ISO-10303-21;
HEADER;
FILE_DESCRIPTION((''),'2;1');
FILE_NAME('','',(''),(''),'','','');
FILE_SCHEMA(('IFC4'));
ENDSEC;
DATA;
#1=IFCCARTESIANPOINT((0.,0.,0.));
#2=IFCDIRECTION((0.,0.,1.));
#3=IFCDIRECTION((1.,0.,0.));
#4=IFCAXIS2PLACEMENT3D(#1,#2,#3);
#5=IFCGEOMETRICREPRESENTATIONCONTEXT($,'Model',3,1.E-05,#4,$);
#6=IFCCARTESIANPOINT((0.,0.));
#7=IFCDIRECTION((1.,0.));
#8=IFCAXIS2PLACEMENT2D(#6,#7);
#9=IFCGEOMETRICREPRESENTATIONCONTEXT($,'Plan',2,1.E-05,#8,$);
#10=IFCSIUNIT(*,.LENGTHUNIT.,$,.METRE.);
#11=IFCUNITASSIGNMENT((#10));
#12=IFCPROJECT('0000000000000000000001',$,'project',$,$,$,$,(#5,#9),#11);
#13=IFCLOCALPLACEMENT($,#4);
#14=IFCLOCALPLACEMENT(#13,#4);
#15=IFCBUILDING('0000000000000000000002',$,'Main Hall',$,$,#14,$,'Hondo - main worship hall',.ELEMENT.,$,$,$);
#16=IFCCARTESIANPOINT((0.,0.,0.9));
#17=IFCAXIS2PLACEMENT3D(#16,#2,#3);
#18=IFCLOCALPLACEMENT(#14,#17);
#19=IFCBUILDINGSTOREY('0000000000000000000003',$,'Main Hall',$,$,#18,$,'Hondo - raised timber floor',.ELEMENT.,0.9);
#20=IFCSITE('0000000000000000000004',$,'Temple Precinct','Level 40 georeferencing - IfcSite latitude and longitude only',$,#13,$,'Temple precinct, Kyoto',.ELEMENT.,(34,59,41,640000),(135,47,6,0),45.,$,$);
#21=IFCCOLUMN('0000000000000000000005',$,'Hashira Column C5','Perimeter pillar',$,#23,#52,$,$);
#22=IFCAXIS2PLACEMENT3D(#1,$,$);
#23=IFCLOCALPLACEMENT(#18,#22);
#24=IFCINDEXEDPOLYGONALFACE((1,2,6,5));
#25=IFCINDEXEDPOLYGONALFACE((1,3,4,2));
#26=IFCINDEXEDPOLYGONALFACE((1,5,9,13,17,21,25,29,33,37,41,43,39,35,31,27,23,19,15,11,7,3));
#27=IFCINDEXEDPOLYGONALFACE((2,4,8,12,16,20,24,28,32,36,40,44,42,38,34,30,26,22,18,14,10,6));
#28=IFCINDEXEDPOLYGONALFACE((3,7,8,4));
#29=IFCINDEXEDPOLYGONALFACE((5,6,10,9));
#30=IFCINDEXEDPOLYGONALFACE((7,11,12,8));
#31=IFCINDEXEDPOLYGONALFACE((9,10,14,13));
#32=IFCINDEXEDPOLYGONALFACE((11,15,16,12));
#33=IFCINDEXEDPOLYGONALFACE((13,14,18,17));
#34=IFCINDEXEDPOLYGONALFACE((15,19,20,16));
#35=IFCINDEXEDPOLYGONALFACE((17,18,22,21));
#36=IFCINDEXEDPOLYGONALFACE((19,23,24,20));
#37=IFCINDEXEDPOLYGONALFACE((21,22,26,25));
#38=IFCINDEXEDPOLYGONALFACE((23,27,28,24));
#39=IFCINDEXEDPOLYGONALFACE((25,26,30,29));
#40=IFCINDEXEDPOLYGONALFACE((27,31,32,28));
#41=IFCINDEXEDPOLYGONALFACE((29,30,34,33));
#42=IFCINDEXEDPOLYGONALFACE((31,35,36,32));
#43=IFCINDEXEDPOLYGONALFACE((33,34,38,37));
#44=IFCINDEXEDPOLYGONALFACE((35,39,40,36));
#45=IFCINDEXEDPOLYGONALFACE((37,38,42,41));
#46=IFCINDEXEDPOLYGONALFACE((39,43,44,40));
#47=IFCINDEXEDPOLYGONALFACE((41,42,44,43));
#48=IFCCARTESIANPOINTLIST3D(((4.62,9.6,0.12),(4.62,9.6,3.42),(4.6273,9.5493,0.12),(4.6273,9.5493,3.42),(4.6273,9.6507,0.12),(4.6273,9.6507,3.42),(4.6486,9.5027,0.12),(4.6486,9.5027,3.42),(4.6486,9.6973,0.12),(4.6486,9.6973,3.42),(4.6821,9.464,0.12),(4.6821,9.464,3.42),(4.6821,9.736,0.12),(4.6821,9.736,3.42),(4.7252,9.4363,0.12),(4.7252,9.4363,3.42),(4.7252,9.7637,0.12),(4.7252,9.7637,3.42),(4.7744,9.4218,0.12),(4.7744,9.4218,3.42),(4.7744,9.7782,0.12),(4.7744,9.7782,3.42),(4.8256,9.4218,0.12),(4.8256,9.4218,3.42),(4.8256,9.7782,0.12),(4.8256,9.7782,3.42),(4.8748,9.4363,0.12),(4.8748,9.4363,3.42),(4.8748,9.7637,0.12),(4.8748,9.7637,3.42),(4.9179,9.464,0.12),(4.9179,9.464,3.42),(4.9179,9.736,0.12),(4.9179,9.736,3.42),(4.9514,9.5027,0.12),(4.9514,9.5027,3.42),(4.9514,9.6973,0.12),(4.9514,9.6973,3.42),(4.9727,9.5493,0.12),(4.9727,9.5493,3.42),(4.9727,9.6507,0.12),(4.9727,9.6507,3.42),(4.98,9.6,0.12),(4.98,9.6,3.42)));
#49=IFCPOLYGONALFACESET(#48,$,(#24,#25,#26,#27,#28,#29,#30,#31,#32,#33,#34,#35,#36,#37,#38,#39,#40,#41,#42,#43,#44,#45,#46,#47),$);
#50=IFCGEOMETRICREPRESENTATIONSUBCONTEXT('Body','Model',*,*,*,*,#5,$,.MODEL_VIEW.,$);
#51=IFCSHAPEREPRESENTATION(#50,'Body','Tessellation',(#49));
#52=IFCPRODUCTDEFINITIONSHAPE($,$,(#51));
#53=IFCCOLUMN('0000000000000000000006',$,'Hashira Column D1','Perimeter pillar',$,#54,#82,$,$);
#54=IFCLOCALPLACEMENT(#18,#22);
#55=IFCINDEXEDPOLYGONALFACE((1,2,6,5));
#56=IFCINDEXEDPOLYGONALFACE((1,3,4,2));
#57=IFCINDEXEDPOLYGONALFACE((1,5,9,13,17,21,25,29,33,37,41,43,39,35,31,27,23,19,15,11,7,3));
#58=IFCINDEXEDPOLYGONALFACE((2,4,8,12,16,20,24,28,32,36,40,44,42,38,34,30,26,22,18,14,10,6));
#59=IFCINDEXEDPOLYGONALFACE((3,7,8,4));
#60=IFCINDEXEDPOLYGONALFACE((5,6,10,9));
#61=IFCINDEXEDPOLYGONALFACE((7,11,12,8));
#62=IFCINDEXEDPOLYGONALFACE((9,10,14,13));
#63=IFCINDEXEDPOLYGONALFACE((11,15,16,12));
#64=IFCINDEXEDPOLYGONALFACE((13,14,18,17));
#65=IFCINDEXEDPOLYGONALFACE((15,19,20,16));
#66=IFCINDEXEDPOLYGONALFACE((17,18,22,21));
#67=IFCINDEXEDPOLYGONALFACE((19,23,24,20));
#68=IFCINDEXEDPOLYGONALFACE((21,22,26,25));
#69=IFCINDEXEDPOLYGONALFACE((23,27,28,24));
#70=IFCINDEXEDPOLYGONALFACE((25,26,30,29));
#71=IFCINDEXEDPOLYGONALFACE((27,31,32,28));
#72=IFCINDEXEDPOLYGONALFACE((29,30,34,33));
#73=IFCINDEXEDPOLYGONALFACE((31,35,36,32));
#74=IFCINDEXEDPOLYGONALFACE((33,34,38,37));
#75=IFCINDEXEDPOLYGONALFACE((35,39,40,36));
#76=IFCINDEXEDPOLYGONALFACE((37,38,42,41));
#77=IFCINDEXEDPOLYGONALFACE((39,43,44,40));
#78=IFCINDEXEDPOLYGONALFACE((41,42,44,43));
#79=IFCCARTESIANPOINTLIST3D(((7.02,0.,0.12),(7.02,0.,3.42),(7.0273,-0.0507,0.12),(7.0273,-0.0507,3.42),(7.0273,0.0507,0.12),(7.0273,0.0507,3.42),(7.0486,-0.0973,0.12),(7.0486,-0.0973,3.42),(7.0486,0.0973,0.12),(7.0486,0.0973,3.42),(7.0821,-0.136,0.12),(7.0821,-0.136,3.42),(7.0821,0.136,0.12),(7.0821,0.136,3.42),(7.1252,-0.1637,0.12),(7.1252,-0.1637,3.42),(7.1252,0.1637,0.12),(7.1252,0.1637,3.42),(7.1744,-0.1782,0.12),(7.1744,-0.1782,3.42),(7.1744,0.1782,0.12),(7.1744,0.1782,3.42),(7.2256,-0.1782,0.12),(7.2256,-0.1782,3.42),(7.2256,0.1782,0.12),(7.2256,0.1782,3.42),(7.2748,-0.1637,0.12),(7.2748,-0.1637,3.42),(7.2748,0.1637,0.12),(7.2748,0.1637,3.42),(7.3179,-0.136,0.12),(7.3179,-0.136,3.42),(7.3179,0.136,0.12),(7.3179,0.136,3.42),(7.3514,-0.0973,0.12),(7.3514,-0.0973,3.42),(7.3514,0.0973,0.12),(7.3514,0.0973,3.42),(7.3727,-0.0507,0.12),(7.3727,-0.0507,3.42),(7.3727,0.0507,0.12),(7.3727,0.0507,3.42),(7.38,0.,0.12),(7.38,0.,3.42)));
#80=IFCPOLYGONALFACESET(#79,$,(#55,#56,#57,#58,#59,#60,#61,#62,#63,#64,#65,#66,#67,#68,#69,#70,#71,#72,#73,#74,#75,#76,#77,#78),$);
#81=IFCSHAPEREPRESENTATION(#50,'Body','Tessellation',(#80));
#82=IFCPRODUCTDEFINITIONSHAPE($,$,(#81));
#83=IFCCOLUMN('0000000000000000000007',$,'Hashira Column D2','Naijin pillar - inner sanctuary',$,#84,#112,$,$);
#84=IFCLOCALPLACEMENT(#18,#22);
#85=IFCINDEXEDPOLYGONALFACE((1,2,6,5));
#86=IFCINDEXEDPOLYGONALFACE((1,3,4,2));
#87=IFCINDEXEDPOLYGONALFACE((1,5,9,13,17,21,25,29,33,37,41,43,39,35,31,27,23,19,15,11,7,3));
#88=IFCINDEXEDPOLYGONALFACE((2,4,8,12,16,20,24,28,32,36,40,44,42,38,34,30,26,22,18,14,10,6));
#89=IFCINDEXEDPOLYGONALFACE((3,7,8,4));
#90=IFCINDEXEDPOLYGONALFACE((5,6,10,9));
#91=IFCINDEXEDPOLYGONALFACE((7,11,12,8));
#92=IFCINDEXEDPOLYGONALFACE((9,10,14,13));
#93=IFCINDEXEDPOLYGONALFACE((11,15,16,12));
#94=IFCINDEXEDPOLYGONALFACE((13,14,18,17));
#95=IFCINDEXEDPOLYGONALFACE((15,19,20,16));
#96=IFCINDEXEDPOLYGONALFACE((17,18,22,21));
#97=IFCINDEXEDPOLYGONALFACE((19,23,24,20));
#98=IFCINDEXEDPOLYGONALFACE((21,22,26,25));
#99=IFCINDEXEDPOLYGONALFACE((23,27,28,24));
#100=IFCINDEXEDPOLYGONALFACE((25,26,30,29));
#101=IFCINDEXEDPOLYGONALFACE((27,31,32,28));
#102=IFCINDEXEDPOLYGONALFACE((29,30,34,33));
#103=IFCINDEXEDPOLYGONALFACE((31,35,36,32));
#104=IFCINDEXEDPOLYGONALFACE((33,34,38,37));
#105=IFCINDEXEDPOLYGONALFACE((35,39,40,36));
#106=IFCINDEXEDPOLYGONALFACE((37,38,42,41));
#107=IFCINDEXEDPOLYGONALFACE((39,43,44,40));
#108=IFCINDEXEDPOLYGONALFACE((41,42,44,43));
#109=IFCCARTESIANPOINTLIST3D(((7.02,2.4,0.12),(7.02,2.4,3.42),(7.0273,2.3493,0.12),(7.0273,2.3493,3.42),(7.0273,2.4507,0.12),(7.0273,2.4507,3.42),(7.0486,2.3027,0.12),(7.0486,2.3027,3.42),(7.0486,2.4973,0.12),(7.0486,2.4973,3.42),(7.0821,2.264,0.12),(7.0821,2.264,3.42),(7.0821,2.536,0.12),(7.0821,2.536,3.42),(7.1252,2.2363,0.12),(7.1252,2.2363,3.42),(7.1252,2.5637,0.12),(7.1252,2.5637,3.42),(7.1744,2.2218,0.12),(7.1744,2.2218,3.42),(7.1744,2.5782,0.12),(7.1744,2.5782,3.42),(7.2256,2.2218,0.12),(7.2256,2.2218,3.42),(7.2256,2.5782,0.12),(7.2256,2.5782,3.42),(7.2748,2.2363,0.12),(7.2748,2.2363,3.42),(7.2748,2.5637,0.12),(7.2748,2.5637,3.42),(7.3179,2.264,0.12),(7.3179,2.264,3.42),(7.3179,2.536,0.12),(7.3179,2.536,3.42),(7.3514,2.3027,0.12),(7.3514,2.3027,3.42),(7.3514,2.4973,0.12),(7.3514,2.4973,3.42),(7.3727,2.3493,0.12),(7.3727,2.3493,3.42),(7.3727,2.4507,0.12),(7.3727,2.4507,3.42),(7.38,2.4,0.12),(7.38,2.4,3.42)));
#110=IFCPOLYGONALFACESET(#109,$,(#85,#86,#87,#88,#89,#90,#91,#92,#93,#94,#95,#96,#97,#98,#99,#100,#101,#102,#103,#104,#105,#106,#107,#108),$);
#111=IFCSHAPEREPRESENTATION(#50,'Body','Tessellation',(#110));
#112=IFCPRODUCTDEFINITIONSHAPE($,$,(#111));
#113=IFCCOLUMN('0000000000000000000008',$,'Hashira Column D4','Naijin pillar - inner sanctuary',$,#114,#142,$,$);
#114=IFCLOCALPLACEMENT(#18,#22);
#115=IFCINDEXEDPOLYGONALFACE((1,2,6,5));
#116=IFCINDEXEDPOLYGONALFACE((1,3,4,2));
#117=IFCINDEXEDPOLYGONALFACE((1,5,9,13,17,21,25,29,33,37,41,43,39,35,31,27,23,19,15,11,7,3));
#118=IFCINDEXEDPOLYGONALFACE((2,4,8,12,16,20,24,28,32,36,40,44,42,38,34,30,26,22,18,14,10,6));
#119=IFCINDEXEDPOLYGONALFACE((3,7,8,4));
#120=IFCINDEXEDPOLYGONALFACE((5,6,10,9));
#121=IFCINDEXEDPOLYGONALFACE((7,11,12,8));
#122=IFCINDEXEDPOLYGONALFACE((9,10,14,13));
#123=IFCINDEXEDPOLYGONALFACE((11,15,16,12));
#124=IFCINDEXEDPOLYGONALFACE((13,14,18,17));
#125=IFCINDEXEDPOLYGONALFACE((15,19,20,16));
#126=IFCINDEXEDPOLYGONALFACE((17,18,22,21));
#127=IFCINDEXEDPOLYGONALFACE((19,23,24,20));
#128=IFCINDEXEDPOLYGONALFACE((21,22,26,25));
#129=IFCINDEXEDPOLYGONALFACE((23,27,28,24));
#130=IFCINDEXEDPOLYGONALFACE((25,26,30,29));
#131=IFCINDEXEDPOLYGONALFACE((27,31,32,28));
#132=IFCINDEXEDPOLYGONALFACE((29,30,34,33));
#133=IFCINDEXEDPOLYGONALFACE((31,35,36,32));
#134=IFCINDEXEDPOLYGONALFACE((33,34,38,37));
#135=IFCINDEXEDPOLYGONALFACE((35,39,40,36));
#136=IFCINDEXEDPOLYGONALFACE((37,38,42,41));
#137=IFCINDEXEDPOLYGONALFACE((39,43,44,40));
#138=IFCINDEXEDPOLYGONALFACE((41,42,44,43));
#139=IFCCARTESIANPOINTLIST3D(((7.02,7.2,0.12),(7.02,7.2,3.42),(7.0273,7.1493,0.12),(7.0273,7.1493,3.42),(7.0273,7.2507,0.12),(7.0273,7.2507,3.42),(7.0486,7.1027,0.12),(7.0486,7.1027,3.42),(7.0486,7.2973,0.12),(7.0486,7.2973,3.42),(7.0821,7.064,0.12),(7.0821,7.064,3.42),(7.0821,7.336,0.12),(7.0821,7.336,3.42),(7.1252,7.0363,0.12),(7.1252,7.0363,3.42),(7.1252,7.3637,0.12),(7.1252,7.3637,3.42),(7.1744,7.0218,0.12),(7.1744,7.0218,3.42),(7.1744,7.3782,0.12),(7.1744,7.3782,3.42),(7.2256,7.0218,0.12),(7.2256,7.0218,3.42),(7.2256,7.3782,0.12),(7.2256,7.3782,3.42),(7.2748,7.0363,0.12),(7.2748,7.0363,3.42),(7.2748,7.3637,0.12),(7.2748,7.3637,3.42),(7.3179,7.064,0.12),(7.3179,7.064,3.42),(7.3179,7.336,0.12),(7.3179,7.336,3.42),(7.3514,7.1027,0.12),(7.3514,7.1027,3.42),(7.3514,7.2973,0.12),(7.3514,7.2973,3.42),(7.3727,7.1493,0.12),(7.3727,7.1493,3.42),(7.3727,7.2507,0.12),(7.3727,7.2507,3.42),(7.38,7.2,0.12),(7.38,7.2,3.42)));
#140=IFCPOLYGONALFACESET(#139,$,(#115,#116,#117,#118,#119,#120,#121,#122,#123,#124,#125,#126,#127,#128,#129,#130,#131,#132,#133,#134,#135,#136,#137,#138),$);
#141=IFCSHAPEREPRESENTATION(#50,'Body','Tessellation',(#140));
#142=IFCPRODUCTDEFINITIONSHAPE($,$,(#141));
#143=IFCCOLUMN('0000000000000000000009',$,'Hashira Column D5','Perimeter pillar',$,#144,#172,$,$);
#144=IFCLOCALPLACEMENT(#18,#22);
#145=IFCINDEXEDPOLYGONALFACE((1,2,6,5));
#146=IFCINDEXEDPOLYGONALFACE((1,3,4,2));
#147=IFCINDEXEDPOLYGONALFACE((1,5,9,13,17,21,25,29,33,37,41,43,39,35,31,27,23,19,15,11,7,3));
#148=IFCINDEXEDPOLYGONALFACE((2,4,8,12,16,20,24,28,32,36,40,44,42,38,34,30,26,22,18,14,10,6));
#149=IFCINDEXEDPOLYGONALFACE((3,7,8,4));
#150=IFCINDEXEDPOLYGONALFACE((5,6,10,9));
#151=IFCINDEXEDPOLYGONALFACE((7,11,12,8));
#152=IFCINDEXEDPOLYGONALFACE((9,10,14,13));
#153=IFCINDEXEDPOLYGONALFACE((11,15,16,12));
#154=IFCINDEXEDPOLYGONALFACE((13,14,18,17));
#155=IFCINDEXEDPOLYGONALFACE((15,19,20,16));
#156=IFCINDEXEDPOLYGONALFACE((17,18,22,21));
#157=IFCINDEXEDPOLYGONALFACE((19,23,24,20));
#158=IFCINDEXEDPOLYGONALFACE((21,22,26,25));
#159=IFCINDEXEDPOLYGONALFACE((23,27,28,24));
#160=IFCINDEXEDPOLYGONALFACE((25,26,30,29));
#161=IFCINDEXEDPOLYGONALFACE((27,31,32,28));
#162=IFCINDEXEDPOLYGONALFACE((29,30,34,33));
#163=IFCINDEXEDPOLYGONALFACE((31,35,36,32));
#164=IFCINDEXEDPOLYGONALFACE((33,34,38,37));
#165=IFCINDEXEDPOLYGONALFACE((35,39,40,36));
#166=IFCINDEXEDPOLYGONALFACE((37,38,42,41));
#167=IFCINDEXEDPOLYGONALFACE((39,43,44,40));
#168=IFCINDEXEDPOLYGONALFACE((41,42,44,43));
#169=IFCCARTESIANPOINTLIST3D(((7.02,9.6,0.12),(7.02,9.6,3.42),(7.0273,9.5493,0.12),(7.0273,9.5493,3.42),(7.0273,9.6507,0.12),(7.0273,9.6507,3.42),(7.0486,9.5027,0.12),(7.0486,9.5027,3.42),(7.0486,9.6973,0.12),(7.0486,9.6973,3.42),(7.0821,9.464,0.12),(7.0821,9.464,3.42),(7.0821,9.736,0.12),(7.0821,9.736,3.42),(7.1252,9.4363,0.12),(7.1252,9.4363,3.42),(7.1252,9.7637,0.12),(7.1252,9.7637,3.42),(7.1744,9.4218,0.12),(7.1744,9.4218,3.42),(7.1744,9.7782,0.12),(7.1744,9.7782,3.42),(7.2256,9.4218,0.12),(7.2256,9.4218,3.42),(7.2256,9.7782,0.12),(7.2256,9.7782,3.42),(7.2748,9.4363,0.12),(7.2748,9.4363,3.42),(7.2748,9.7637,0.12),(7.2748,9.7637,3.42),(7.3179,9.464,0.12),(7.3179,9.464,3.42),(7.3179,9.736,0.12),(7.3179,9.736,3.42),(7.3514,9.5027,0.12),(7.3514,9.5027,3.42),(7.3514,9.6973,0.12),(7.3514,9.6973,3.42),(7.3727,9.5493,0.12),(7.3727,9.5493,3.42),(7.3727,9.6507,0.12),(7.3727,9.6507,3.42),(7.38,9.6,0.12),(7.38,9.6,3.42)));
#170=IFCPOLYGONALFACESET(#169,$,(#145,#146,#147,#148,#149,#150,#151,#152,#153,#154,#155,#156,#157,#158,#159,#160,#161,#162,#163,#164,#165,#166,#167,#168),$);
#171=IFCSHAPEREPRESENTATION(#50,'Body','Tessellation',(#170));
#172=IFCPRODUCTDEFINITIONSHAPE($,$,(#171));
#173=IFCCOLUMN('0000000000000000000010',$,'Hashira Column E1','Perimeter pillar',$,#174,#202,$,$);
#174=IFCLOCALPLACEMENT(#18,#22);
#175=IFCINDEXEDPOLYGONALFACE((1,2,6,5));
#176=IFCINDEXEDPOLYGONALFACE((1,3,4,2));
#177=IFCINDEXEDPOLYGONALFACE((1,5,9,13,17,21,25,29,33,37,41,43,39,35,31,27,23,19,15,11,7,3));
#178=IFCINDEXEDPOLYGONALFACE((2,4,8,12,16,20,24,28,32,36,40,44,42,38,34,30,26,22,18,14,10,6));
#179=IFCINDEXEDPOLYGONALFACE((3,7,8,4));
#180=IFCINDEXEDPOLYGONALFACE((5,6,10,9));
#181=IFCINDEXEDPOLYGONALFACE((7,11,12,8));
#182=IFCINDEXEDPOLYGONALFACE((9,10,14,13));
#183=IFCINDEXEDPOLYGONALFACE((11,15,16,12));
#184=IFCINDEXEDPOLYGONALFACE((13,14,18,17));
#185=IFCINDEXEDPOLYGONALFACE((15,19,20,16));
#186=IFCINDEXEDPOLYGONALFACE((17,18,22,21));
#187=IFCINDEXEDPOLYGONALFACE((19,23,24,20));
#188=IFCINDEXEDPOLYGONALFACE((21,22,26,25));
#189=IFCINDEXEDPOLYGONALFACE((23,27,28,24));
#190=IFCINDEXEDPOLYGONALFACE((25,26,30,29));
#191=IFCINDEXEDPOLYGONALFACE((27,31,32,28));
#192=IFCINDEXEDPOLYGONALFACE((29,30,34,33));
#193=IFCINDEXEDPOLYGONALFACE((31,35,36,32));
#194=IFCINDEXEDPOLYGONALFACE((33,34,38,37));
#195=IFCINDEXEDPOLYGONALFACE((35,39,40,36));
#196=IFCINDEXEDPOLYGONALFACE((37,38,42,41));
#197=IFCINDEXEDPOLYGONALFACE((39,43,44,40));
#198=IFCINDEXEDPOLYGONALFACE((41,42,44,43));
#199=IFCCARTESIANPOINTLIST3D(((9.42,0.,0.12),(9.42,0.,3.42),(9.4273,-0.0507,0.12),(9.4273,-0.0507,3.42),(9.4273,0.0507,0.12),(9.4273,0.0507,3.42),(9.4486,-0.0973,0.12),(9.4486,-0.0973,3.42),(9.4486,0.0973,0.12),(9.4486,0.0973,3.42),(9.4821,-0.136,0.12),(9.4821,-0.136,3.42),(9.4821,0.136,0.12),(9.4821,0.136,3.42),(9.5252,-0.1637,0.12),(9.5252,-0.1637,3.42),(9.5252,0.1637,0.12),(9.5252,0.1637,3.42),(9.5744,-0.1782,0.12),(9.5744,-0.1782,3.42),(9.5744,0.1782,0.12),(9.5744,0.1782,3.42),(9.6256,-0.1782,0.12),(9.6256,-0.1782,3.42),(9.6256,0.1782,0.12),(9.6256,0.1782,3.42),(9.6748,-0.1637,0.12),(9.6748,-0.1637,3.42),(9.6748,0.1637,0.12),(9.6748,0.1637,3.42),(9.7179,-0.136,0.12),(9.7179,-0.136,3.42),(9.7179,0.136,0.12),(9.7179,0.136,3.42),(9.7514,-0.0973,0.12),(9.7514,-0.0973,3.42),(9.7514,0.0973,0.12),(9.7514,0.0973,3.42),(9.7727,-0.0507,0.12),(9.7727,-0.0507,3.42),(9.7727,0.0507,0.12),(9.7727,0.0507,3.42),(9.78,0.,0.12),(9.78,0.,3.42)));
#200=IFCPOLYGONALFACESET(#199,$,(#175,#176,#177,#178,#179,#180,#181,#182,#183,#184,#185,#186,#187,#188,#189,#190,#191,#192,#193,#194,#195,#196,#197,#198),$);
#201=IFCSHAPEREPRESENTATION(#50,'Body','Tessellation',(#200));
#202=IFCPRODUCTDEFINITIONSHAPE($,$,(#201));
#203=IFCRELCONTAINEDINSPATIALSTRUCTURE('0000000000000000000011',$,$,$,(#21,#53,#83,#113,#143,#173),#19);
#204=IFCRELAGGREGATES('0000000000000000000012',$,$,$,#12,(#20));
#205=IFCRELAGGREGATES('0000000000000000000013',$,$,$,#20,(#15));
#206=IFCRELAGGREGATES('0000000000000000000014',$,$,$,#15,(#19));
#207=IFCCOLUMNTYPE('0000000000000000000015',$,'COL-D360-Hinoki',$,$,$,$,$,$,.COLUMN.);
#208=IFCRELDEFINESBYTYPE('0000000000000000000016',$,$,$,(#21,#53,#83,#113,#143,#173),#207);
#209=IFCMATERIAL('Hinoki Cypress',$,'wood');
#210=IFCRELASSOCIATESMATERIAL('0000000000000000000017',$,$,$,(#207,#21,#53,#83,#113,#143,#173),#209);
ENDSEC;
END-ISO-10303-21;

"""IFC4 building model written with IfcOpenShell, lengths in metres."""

from ifc_helpers import new_model, si_unit, frame, origin_with_axes, origin_2d_with_axis, place, context, subcontext, project, spatial, circle, extrude, material, material_profile, profile_set, profile_usage, type_object, element, save


model = new_model("IFC4")

# Units and contexts
model_context = context("Model", 3, precision=1e-05, world=origin_with_axes())
plan_context = context("Plan", 2, precision=1e-05, world=origin_2d_with_axis())
body_context = subcontext(model_context, "Body", "Model", "MODEL_VIEW")
ifc_project = project(units=[si_unit("LENGTHUNIT", "METRE")], contexts=[model_context, plan_context])

# Site, building, storey
site_placement = place(None, origin_with_axes())
site = spatial("IfcSite", under=ifc_project, at=site_placement, Name="Temple Precinct", Description="Level 40 georeferencing - IfcSite latitude and longitude only", LongName="Temple precinct, Kyoto", CompositionType="ELEMENT", RefLatitude=(34, 59, 41, 640000), RefLongitude=(135, 47, 6, 0), RefElevation=45.0)
building_placement = place(site_placement, origin_with_axes())
building = spatial("IfcBuilding", under=site, at=building_placement, Name="Main Hall", LongName="Hondo - main worship hall", CompositionType="ELEMENT")
storey_placement = place(building_placement, frame((0.0, 0.0, 0.9), z_axis=(0.0, 0.0, 1.0), x_axis=(1.0, 0.0, 0.0)))
storey = spatial("IfcBuildingStorey", under=building, at=storey_placement, Name="Main Hall", LongName="Hondo - raised timber floor", CompositionType="ELEMENT", Elevation=0.9)

# Columns
ifc_material_1 = material(Name="Hinoki Cypress", Category="wood")
ifc_material_profile = material_profile(ifc_material_1, circle(Radius=0.18))
ifc_profile_set = profile_set([ifc_material_profile], Name="COL-D360-Hinoki")
ifc_profile_usage_1 = profile_usage(ifc_profile_set)
column_type = type_object("IfcColumnType", Name="COL-D360-Hinoki", PredefinedType="COLUMN", material=ifc_profile_set)
column_1_placement = place(storey_placement, frame((4.8, 9.6, 0.12), z_axis=(0.0, 0.0, 1.0), x_axis=(1.0, 0.0, 0.0)))
element("IfcColumn", 1, at=column_1_placement, inside=storey, type_object=column_type, material=ifc_profile_usage_1, Name="Hashira Column C5", Description="Perimeter pillar", context=body_context, shape_type="SweptSolid", body=[
    extrude(circle(Radius=0.18), origin_with_axes(), (0.0, 0.0, 1.0), 3.3),
])
ifc_profile_usage_2 = profile_usage(ifc_profile_set)
column_2_placement = place(storey_placement, frame((7.2, 0.0, 0.12), z_axis=(0.0, 0.0, 1.0), x_axis=(1.0, 0.0, 0.0)))
element("IfcColumn", 2, at=column_2_placement, inside=storey, type_object=column_type, material=ifc_profile_usage_2, Name="Hashira Column D1", Description="Perimeter pillar", context=body_context, shape_type="SweptSolid", body=[
    extrude(circle(Radius=0.18), origin_with_axes(), (0.0, 0.0, 1.0), 3.3),
])
ifc_profile_usage_3 = profile_usage(ifc_profile_set)
column_3_placement = place(storey_placement, frame((7.2, 2.4, 0.12), z_axis=(0.0, 0.0, 1.0), x_axis=(1.0, 0.0, 0.0)))
element("IfcColumn", 3, at=column_3_placement, inside=storey, type_object=column_type, material=ifc_profile_usage_3, Name="Hashira Column D2", Description="Naijin pillar - inner sanctuary", context=body_context, shape_type="SweptSolid", body=[
    extrude(circle(Radius=0.18), origin_with_axes(), (0.0, 0.0, 1.0), 3.3),
])
ifc_profile_usage_4 = profile_usage(ifc_profile_set)
column_4_placement = place(storey_placement, frame((7.2, 7.2, 0.12), z_axis=(0.0, 0.0, 1.0), x_axis=(1.0, 0.0, 0.0)))
element("IfcColumn", 4, at=column_4_placement, inside=storey, type_object=column_type, material=ifc_profile_usage_4, Name="Hashira Column D4", Description="Naijin pillar - inner sanctuary", context=body_context, shape_type="SweptSolid", body=[
    extrude(circle(Radius=0.18), origin_with_axes(), (0.0, 0.0, 1.0), 3.3),
])
ifc_profile_usage_5 = profile_usage(ifc_profile_set)
column_5_placement = place(storey_placement, frame((7.2, 9.6, 0.12), z_axis=(0.0, 0.0, 1.0), x_axis=(1.0, 0.0, 0.0)))
element("IfcColumn", 5, at=column_5_placement, inside=storey, type_object=column_type, material=ifc_profile_usage_5, Name="Hashira Column D5", Description="Perimeter pillar", context=body_context, shape_type="SweptSolid", body=[
    extrude(circle(Radius=0.18), origin_with_axes(), (0.0, 0.0, 1.0), 3.3),
])
ifc_profile_usage_6 = profile_usage(ifc_profile_set)
column_6_placement = place(storey_placement, frame((9.6, 0.0, 0.12), z_axis=(0.0, 0.0, 1.0), x_axis=(1.0, 0.0, 0.0)))
element("IfcColumn", 6, at=column_6_placement, inside=storey, type_object=column_type, material=ifc_profile_usage_6, Name="Hashira Column E1", Description="Perimeter pillar", context=body_context, shape_type="SweptSolid", body=[
    extrude(circle(Radius=0.18), origin_with_axes(), (0.0, 0.0, 1.0), 3.3),
])

save(model, "model.ifc")
